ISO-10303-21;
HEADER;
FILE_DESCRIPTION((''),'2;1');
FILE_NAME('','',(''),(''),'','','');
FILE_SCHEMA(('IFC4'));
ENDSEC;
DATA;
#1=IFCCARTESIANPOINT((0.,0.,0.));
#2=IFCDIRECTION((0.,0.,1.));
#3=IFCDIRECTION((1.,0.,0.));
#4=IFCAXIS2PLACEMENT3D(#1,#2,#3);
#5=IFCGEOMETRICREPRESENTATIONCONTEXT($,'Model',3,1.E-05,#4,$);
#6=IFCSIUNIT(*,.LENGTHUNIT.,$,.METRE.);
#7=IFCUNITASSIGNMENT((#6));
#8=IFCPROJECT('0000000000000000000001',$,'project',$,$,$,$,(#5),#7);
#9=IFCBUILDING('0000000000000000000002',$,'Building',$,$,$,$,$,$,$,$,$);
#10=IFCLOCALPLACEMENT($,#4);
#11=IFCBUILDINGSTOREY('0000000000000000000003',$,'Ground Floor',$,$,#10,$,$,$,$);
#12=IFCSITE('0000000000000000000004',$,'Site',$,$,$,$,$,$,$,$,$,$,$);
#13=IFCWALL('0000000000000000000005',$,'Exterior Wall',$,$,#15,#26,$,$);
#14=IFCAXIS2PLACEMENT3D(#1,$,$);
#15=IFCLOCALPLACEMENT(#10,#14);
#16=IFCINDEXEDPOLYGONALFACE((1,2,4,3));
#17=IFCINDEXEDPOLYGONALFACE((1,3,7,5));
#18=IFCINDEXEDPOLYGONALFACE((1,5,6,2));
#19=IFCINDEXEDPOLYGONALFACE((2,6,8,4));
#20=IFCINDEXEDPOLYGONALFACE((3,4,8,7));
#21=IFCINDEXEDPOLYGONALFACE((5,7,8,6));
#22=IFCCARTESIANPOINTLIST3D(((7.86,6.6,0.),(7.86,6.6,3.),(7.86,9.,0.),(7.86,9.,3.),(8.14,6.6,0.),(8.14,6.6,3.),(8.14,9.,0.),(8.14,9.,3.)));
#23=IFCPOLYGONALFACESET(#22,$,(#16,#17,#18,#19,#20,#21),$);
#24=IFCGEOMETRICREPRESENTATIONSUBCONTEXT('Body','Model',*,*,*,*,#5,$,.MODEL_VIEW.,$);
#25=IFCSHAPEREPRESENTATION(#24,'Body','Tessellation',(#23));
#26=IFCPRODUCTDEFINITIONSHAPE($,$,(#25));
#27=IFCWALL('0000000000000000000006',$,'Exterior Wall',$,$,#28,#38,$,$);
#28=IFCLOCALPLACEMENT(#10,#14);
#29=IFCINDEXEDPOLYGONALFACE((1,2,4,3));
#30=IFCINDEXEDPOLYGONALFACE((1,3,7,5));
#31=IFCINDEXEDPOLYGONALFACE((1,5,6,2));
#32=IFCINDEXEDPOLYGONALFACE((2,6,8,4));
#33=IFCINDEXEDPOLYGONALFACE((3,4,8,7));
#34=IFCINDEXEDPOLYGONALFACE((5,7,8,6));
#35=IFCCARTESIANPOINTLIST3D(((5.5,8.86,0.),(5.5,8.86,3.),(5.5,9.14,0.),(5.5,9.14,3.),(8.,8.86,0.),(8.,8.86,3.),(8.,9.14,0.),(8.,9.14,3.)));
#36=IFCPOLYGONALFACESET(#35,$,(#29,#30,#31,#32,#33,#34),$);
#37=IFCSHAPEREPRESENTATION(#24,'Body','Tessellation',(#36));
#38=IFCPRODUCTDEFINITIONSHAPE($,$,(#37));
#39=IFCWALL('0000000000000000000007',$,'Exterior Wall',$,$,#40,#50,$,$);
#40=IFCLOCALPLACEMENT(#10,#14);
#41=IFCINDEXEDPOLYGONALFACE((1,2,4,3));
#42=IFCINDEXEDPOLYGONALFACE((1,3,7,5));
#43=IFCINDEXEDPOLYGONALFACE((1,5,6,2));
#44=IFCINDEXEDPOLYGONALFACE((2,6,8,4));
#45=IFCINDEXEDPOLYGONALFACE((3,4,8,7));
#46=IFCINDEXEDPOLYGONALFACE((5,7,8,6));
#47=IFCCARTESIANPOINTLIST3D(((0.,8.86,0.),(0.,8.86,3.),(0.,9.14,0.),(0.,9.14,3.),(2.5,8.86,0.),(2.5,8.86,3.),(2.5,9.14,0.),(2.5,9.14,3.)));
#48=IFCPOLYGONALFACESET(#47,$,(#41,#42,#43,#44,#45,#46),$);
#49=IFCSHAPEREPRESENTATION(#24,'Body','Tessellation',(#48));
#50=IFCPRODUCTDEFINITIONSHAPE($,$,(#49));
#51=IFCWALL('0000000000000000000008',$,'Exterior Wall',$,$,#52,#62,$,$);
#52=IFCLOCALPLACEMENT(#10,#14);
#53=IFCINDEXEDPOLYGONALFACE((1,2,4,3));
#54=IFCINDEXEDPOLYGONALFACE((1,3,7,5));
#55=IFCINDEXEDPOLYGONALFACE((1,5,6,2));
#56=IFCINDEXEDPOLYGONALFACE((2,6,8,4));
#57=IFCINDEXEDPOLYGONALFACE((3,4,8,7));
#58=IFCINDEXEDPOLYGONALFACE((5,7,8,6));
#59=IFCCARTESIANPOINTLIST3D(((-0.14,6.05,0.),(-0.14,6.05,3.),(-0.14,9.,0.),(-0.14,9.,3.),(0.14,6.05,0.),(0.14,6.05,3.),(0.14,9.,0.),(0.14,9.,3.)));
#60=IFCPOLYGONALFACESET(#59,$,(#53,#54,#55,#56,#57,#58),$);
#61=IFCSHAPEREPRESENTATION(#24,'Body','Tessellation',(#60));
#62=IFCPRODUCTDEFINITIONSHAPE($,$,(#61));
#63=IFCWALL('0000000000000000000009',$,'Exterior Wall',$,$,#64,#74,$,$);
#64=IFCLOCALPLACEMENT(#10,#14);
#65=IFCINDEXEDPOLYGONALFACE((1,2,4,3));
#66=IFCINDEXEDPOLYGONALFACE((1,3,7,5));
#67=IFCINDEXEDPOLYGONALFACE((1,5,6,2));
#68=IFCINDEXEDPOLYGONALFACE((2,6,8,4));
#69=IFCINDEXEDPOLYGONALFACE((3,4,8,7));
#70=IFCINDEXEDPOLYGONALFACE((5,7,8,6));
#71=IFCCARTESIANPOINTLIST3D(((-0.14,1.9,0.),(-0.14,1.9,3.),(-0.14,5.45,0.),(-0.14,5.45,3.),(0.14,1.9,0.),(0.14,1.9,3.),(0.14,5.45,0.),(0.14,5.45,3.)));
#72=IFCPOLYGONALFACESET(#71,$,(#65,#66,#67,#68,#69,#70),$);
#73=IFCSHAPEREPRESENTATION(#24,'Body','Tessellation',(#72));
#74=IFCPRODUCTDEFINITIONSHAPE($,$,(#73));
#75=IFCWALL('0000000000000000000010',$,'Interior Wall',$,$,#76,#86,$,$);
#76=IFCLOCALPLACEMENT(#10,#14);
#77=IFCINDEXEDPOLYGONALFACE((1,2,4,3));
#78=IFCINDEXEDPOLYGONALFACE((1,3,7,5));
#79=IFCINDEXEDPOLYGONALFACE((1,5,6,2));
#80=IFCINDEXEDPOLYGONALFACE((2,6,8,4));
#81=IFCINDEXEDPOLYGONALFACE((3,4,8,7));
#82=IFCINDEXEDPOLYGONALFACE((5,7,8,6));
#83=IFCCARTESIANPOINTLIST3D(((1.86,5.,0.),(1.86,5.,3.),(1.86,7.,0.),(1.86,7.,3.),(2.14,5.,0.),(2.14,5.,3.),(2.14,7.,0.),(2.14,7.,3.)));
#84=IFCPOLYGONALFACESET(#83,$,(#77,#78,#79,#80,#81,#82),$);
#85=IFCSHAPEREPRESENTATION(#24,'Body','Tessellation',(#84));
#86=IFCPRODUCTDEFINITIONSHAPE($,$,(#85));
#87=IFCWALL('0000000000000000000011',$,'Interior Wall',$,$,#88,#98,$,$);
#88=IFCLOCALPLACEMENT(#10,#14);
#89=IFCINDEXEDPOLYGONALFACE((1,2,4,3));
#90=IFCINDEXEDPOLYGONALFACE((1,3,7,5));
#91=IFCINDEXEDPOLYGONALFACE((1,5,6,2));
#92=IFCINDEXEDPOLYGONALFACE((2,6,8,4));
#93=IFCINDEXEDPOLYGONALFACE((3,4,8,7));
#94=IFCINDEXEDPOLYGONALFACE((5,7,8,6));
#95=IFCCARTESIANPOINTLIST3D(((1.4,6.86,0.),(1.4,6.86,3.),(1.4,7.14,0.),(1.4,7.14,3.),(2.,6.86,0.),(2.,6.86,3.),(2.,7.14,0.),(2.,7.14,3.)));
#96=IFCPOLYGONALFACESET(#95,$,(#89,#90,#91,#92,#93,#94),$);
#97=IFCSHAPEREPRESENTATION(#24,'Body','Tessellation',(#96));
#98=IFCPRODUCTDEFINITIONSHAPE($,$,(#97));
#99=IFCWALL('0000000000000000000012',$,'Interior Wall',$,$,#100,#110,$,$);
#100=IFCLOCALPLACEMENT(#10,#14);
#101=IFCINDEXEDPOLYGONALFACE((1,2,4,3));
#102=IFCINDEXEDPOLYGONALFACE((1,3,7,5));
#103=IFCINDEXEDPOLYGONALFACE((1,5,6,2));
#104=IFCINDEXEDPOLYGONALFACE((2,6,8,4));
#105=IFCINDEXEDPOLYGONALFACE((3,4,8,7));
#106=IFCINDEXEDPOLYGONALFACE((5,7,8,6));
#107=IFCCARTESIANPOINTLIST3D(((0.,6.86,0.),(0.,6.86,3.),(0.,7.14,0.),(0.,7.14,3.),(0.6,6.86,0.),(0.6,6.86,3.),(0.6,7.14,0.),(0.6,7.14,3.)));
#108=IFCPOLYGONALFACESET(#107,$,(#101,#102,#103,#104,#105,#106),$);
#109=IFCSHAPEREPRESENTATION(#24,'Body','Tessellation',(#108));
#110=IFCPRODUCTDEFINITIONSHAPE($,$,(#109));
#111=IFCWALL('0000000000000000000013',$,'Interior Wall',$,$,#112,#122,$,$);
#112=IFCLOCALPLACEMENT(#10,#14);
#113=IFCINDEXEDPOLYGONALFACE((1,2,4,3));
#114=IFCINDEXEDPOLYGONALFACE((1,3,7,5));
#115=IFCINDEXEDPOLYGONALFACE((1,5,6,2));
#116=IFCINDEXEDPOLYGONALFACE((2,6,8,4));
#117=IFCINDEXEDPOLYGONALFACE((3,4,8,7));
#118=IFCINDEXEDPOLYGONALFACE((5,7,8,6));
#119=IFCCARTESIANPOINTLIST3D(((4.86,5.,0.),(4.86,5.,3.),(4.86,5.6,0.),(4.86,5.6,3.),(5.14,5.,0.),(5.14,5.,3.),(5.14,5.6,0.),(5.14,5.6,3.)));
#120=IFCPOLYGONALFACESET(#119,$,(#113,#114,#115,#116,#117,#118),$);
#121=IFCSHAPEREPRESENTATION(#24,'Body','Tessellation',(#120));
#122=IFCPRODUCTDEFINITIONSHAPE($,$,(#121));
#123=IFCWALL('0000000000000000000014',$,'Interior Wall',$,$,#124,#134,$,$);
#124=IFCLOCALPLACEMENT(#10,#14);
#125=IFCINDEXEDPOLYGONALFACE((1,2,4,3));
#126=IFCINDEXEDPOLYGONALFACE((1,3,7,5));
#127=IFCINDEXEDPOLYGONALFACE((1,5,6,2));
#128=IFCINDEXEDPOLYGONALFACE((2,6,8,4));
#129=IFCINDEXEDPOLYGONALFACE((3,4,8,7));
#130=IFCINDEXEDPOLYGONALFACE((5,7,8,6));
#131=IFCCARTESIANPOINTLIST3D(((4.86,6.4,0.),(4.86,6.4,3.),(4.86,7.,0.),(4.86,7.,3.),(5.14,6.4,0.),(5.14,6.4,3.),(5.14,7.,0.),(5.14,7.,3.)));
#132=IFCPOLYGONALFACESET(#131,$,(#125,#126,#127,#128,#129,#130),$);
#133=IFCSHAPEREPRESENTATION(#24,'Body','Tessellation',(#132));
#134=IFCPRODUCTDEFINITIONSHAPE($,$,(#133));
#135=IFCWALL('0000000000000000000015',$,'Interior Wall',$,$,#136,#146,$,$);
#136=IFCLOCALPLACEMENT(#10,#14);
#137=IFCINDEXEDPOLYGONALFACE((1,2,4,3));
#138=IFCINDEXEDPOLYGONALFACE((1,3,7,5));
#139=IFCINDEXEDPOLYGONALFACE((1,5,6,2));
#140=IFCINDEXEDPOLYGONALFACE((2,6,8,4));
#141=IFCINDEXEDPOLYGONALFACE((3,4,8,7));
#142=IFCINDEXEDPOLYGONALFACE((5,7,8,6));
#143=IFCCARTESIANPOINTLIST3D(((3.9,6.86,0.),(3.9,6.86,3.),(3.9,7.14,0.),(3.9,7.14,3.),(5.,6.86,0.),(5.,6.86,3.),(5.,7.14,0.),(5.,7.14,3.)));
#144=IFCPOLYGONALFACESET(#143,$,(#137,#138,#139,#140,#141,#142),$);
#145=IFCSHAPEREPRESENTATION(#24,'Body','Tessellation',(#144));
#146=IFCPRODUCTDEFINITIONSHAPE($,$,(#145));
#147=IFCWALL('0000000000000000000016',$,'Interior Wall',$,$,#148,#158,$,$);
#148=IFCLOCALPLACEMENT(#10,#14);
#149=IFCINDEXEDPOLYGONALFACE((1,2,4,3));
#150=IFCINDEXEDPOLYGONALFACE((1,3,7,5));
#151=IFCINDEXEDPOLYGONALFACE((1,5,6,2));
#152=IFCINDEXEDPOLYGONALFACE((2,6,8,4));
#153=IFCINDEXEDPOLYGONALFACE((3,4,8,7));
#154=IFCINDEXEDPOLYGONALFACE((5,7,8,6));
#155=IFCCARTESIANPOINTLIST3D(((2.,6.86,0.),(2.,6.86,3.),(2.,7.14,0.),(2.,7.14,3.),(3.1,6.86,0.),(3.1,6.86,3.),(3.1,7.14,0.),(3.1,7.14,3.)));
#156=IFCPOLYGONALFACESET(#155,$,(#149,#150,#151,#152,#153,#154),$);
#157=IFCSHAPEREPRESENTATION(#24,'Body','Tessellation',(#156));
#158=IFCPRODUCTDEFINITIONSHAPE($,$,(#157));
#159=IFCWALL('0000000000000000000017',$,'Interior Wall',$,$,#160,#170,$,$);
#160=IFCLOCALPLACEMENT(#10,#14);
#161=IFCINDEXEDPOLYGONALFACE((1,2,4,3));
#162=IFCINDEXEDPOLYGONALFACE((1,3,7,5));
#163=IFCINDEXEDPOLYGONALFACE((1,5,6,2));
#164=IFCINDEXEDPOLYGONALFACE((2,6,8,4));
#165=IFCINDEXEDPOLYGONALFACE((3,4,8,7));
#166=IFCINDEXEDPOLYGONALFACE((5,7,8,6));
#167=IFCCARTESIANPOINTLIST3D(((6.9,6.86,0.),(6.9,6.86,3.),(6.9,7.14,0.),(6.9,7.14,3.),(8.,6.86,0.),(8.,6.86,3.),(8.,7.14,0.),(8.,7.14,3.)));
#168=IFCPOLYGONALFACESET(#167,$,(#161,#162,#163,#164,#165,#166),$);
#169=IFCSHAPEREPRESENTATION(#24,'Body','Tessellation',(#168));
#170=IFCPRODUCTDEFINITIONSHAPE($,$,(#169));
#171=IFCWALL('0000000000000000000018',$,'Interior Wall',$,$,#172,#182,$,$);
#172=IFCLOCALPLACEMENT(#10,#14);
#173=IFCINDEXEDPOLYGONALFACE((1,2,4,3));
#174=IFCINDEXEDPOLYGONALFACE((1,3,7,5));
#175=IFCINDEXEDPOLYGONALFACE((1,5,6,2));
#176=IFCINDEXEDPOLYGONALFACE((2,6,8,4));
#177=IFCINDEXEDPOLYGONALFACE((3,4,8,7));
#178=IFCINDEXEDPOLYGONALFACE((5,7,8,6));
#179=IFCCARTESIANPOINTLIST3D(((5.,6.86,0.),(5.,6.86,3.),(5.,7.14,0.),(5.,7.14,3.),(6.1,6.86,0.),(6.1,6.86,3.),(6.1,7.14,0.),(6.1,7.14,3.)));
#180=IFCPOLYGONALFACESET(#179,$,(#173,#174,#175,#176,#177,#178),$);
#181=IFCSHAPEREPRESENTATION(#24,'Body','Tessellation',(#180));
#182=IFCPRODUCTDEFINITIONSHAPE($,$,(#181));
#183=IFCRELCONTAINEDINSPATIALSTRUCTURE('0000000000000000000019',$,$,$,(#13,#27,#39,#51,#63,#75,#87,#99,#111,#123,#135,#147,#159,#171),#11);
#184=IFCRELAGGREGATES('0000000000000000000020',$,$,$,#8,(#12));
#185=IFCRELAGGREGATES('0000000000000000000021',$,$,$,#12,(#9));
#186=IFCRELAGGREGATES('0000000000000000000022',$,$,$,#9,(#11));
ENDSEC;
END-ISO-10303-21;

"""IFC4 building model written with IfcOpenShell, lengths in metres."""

from ifc_helpers import new_model, si_unit, frame, origin_with_axes, place, context, subcontext, project, spatial, indexed_curve, outline, extrude, element, save


model = new_model("IFC4")

# Units and contexts
model_context = context("Model", 3, precision=1e-05, world=origin_with_axes())
body_context = subcontext(model_context, "Body", "Model", "MODEL_VIEW")
ifc_project = project(units=[si_unit("LENGTHUNIT", "METRE")], contexts=[model_context])

# Site, building, storey
site = spatial("IfcSite", under=ifc_project, Name="Site")
building = spatial("IfcBuilding", under=site, Name="Building")
storey_placement = place(None, origin_with_axes())
storey = spatial("IfcBuildingStorey", under=building, at=storey_placement, Name="Ground Floor")

# Walls
wall_1_placement = place(storey_placement, frame((8.0, 6.6, 0.0), z_axis=(0.0, 0.0, 1.0), x_axis=(0.0, 1.0, 0.0)))
element("IfcWall", 1, at=wall_1_placement, inside=storey, Name="Exterior Wall", context=body_context, shape_type="SweptSolid", body=[
    extrude(outline(indexed_curve([(0.0, 0.0), (0.0, 0.28), (2.4, 0.28), (2.4, 0.0), (0.0, 0.0)], self_intersect=False)), frame((0.0, -0.14, 0.0), z_axis=(0.0, 0.0, 1.0), x_axis=(1.0, 0.0, 0.0)), (0.0, 0.0, 1.0), 3.0),
])
for number, where, z_axis, x_axis, name in (
    (2, (8.0, 9.0, 0.0), (0.0, 0.0, 1.0), (-1.0, 0.0, 0.0), "Exterior Wall"),
    (3, (2.5, 9.0, 0.0), (0.0, 0.0, 1.0), (-1.0, 0.0, 0.0), "Exterior Wall"),
):
    element("IfcWall", number, at=place(storey_placement, frame(where, z_axis=z_axis, x_axis=x_axis)), inside=storey, Name=name, context=body_context, shape_type="SweptSolid", body=[
        extrude(outline(indexed_curve([(0.0, 0.0), (0.0, 0.28), (2.5, 0.28), (2.5, 0.0), (0.0, 0.0)], self_intersect=False)), frame((0.0, -0.14, 0.0), z_axis=(0.0, 0.0, 1.0), x_axis=(1.0, 0.0, 0.0)), (0.0, 0.0, 1.0), 3.0),
    ])
wall_2_placement = place(storey_placement, frame((0.0, 9.0, 0.0), z_axis=(0.0, 0.0, 1.0), x_axis=(0.0, -1.0, 0.0)))
element("IfcWall", 4, at=wall_2_placement, inside=storey, Name="Exterior Wall", context=body_context, shape_type="SweptSolid", body=[
    extrude(outline(indexed_curve([(0.0, 0.0), (0.0, 0.28), (2.95, 0.28), (2.95, 0.0), (0.0, 0.0)], self_intersect=False)), frame((0.0, -0.14, 0.0), z_axis=(0.0, 0.0, 1.0), x_axis=(1.0, 0.0, 0.0)), (0.0, 0.0, 1.0), 3.0),
])
wall_3_placement = place(storey_placement, frame((0.0, 5.45, 0.0), z_axis=(0.0, 0.0, 1.0), x_axis=(0.0, -1.0, 0.0)))
element("IfcWall", 5, at=wall_3_placement, inside=storey, Name="Exterior Wall", context=body_context, shape_type="SweptSolid", body=[
    extrude(outline(indexed_curve([(0.0, 0.0), (0.0, 0.28), (3.55, 0.28), (3.55, 0.0), (0.0, 0.0)], self_intersect=False)), frame((0.0, -0.14, 0.0), z_axis=(0.0, 0.0, 1.0), x_axis=(1.0, 0.0, 0.0)), (0.0, 0.0, 1.0), 3.0),
])
wall_4_placement = place(storey_placement, frame((2.0, 5.0, 0.0), z_axis=(0.0, 0.0, 1.0), x_axis=(0.0, 1.0, 0.0)))
element("IfcWall", 6, at=wall_4_placement, inside=storey, Name="Interior Wall", context=body_context, shape_type="SweptSolid", body=[
    extrude(outline(indexed_curve([(0.0, 0.0), (0.0, 0.28), (2.0, 0.28), (2.0, 0.0), (0.0, 0.0)], self_intersect=False)), frame((0.0, -0.14, 0.0), z_axis=(0.0, 0.0, 1.0), x_axis=(1.0, 0.0, 0.0)), (0.0, 0.0, 1.0), 3.0),
])
for number, where, z_axis, x_axis, name in (
    (7, (2.0, 7.0, 0.0), (0.0, 0.0, 1.0), (-1.0, 0.0, 0.0), "Interior Wall"),
    (8, (0.6, 7.0, 0.0), (0.0, 0.0, 1.0), (-1.0, 0.0, 0.0), "Interior Wall"),
):
    element("IfcWall", number, at=place(storey_placement, frame(where, z_axis=z_axis, x_axis=x_axis)), inside=storey, Name=name, context=body_context, shape_type="SweptSolid", body=[
        extrude(outline(indexed_curve([(0.0, 0.0), (0.0, 0.28), (0.6, 0.28), (0.6, 0.0), (0.0, 0.0)], self_intersect=False)), frame((0.0, -0.14, 0.0), z_axis=(0.0, 0.0, 1.0), x_axis=(1.0, 0.0, 0.0)), (0.0, 0.0, 1.0), 3.0),
    ])
for number, where, z_axis, x_axis, name in (
    (9, (5.0, 5.0, 0.0), (0.0, 0.0, 1.0), (0.0, 1.0, 0.0), "Interior Wall"),
    (10, (5.0, 6.4, 0.0), (0.0, 0.0, 1.0), (0.0, 1.0, 0.0), "Interior Wall"),
):
    element("IfcWall", number, at=place(storey_placement, frame(where, z_axis=z_axis, x_axis=x_axis)), inside=storey, Name=name, context=body_context, shape_type="SweptSolid", body=[
        extrude(outline(indexed_curve([(0.0, 0.0), (0.0, 0.28), (0.6, 0.28), (0.6, 0.0), (0.0, 0.0)], self_intersect=False)), frame((0.0, -0.14, 0.0), z_axis=(0.0, 0.0, 1.0), x_axis=(1.0, 0.0, 0.0)), (0.0, 0.0, 1.0), 3.0),
    ])
for number, where, z_axis, x_axis, name in (
    (11, (5.0, 7.0, 0.0), (0.0, 0.0, 1.0), (-1.0, 0.0, 0.0), "Interior Wall"),
    (12, (3.1, 7.0, 0.0), (0.0, 0.0, 1.0), (-1.0, 0.0, 0.0), "Interior Wall"),
):
    element("IfcWall", number, at=place(storey_placement, frame(where, z_axis=z_axis, x_axis=x_axis)), inside=storey, Name=name, context=body_context, shape_type="SweptSolid", body=[
        extrude(outline(indexed_curve([(0.0, 0.0), (0.0, 0.28), (1.1, 0.28), (1.1, 0.0), (0.0, 0.0)], self_intersect=False)), frame((0.0, -0.14, 0.0), z_axis=(0.0, 0.0, 1.0), x_axis=(1.0, 0.0, 0.0)), (0.0, 0.0, 1.0), 3.0),
    ])
for number, where, z_axis, x_axis, name in (
    (13, (8.0, 7.0, 0.0), (0.0, 0.0, 1.0), (-1.0, 0.0, 0.0), "Interior Wall"),
    (14, (6.1, 7.0, 0.0), (0.0, 0.0, 1.0), (-1.0, 0.0, 0.0), "Interior Wall"),
):
    element("IfcWall", number, at=place(storey_placement, frame(where, z_axis=z_axis, x_axis=x_axis)), inside=storey, Name=name, context=body_context, shape_type="SweptSolid", body=[
        extrude(outline(indexed_curve([(0.0, 0.0), (0.0, 0.28), (1.1, 0.28), (1.1, 0.0), (0.0, 0.0)], self_intersect=False)), frame((0.0, -0.14, 0.0), z_axis=(0.0, 0.0, 1.0), x_axis=(1.0, 0.0, 0.0)), (0.0, 0.0, 1.0), 3.0),
    ])

save(model, "model.ifc")
